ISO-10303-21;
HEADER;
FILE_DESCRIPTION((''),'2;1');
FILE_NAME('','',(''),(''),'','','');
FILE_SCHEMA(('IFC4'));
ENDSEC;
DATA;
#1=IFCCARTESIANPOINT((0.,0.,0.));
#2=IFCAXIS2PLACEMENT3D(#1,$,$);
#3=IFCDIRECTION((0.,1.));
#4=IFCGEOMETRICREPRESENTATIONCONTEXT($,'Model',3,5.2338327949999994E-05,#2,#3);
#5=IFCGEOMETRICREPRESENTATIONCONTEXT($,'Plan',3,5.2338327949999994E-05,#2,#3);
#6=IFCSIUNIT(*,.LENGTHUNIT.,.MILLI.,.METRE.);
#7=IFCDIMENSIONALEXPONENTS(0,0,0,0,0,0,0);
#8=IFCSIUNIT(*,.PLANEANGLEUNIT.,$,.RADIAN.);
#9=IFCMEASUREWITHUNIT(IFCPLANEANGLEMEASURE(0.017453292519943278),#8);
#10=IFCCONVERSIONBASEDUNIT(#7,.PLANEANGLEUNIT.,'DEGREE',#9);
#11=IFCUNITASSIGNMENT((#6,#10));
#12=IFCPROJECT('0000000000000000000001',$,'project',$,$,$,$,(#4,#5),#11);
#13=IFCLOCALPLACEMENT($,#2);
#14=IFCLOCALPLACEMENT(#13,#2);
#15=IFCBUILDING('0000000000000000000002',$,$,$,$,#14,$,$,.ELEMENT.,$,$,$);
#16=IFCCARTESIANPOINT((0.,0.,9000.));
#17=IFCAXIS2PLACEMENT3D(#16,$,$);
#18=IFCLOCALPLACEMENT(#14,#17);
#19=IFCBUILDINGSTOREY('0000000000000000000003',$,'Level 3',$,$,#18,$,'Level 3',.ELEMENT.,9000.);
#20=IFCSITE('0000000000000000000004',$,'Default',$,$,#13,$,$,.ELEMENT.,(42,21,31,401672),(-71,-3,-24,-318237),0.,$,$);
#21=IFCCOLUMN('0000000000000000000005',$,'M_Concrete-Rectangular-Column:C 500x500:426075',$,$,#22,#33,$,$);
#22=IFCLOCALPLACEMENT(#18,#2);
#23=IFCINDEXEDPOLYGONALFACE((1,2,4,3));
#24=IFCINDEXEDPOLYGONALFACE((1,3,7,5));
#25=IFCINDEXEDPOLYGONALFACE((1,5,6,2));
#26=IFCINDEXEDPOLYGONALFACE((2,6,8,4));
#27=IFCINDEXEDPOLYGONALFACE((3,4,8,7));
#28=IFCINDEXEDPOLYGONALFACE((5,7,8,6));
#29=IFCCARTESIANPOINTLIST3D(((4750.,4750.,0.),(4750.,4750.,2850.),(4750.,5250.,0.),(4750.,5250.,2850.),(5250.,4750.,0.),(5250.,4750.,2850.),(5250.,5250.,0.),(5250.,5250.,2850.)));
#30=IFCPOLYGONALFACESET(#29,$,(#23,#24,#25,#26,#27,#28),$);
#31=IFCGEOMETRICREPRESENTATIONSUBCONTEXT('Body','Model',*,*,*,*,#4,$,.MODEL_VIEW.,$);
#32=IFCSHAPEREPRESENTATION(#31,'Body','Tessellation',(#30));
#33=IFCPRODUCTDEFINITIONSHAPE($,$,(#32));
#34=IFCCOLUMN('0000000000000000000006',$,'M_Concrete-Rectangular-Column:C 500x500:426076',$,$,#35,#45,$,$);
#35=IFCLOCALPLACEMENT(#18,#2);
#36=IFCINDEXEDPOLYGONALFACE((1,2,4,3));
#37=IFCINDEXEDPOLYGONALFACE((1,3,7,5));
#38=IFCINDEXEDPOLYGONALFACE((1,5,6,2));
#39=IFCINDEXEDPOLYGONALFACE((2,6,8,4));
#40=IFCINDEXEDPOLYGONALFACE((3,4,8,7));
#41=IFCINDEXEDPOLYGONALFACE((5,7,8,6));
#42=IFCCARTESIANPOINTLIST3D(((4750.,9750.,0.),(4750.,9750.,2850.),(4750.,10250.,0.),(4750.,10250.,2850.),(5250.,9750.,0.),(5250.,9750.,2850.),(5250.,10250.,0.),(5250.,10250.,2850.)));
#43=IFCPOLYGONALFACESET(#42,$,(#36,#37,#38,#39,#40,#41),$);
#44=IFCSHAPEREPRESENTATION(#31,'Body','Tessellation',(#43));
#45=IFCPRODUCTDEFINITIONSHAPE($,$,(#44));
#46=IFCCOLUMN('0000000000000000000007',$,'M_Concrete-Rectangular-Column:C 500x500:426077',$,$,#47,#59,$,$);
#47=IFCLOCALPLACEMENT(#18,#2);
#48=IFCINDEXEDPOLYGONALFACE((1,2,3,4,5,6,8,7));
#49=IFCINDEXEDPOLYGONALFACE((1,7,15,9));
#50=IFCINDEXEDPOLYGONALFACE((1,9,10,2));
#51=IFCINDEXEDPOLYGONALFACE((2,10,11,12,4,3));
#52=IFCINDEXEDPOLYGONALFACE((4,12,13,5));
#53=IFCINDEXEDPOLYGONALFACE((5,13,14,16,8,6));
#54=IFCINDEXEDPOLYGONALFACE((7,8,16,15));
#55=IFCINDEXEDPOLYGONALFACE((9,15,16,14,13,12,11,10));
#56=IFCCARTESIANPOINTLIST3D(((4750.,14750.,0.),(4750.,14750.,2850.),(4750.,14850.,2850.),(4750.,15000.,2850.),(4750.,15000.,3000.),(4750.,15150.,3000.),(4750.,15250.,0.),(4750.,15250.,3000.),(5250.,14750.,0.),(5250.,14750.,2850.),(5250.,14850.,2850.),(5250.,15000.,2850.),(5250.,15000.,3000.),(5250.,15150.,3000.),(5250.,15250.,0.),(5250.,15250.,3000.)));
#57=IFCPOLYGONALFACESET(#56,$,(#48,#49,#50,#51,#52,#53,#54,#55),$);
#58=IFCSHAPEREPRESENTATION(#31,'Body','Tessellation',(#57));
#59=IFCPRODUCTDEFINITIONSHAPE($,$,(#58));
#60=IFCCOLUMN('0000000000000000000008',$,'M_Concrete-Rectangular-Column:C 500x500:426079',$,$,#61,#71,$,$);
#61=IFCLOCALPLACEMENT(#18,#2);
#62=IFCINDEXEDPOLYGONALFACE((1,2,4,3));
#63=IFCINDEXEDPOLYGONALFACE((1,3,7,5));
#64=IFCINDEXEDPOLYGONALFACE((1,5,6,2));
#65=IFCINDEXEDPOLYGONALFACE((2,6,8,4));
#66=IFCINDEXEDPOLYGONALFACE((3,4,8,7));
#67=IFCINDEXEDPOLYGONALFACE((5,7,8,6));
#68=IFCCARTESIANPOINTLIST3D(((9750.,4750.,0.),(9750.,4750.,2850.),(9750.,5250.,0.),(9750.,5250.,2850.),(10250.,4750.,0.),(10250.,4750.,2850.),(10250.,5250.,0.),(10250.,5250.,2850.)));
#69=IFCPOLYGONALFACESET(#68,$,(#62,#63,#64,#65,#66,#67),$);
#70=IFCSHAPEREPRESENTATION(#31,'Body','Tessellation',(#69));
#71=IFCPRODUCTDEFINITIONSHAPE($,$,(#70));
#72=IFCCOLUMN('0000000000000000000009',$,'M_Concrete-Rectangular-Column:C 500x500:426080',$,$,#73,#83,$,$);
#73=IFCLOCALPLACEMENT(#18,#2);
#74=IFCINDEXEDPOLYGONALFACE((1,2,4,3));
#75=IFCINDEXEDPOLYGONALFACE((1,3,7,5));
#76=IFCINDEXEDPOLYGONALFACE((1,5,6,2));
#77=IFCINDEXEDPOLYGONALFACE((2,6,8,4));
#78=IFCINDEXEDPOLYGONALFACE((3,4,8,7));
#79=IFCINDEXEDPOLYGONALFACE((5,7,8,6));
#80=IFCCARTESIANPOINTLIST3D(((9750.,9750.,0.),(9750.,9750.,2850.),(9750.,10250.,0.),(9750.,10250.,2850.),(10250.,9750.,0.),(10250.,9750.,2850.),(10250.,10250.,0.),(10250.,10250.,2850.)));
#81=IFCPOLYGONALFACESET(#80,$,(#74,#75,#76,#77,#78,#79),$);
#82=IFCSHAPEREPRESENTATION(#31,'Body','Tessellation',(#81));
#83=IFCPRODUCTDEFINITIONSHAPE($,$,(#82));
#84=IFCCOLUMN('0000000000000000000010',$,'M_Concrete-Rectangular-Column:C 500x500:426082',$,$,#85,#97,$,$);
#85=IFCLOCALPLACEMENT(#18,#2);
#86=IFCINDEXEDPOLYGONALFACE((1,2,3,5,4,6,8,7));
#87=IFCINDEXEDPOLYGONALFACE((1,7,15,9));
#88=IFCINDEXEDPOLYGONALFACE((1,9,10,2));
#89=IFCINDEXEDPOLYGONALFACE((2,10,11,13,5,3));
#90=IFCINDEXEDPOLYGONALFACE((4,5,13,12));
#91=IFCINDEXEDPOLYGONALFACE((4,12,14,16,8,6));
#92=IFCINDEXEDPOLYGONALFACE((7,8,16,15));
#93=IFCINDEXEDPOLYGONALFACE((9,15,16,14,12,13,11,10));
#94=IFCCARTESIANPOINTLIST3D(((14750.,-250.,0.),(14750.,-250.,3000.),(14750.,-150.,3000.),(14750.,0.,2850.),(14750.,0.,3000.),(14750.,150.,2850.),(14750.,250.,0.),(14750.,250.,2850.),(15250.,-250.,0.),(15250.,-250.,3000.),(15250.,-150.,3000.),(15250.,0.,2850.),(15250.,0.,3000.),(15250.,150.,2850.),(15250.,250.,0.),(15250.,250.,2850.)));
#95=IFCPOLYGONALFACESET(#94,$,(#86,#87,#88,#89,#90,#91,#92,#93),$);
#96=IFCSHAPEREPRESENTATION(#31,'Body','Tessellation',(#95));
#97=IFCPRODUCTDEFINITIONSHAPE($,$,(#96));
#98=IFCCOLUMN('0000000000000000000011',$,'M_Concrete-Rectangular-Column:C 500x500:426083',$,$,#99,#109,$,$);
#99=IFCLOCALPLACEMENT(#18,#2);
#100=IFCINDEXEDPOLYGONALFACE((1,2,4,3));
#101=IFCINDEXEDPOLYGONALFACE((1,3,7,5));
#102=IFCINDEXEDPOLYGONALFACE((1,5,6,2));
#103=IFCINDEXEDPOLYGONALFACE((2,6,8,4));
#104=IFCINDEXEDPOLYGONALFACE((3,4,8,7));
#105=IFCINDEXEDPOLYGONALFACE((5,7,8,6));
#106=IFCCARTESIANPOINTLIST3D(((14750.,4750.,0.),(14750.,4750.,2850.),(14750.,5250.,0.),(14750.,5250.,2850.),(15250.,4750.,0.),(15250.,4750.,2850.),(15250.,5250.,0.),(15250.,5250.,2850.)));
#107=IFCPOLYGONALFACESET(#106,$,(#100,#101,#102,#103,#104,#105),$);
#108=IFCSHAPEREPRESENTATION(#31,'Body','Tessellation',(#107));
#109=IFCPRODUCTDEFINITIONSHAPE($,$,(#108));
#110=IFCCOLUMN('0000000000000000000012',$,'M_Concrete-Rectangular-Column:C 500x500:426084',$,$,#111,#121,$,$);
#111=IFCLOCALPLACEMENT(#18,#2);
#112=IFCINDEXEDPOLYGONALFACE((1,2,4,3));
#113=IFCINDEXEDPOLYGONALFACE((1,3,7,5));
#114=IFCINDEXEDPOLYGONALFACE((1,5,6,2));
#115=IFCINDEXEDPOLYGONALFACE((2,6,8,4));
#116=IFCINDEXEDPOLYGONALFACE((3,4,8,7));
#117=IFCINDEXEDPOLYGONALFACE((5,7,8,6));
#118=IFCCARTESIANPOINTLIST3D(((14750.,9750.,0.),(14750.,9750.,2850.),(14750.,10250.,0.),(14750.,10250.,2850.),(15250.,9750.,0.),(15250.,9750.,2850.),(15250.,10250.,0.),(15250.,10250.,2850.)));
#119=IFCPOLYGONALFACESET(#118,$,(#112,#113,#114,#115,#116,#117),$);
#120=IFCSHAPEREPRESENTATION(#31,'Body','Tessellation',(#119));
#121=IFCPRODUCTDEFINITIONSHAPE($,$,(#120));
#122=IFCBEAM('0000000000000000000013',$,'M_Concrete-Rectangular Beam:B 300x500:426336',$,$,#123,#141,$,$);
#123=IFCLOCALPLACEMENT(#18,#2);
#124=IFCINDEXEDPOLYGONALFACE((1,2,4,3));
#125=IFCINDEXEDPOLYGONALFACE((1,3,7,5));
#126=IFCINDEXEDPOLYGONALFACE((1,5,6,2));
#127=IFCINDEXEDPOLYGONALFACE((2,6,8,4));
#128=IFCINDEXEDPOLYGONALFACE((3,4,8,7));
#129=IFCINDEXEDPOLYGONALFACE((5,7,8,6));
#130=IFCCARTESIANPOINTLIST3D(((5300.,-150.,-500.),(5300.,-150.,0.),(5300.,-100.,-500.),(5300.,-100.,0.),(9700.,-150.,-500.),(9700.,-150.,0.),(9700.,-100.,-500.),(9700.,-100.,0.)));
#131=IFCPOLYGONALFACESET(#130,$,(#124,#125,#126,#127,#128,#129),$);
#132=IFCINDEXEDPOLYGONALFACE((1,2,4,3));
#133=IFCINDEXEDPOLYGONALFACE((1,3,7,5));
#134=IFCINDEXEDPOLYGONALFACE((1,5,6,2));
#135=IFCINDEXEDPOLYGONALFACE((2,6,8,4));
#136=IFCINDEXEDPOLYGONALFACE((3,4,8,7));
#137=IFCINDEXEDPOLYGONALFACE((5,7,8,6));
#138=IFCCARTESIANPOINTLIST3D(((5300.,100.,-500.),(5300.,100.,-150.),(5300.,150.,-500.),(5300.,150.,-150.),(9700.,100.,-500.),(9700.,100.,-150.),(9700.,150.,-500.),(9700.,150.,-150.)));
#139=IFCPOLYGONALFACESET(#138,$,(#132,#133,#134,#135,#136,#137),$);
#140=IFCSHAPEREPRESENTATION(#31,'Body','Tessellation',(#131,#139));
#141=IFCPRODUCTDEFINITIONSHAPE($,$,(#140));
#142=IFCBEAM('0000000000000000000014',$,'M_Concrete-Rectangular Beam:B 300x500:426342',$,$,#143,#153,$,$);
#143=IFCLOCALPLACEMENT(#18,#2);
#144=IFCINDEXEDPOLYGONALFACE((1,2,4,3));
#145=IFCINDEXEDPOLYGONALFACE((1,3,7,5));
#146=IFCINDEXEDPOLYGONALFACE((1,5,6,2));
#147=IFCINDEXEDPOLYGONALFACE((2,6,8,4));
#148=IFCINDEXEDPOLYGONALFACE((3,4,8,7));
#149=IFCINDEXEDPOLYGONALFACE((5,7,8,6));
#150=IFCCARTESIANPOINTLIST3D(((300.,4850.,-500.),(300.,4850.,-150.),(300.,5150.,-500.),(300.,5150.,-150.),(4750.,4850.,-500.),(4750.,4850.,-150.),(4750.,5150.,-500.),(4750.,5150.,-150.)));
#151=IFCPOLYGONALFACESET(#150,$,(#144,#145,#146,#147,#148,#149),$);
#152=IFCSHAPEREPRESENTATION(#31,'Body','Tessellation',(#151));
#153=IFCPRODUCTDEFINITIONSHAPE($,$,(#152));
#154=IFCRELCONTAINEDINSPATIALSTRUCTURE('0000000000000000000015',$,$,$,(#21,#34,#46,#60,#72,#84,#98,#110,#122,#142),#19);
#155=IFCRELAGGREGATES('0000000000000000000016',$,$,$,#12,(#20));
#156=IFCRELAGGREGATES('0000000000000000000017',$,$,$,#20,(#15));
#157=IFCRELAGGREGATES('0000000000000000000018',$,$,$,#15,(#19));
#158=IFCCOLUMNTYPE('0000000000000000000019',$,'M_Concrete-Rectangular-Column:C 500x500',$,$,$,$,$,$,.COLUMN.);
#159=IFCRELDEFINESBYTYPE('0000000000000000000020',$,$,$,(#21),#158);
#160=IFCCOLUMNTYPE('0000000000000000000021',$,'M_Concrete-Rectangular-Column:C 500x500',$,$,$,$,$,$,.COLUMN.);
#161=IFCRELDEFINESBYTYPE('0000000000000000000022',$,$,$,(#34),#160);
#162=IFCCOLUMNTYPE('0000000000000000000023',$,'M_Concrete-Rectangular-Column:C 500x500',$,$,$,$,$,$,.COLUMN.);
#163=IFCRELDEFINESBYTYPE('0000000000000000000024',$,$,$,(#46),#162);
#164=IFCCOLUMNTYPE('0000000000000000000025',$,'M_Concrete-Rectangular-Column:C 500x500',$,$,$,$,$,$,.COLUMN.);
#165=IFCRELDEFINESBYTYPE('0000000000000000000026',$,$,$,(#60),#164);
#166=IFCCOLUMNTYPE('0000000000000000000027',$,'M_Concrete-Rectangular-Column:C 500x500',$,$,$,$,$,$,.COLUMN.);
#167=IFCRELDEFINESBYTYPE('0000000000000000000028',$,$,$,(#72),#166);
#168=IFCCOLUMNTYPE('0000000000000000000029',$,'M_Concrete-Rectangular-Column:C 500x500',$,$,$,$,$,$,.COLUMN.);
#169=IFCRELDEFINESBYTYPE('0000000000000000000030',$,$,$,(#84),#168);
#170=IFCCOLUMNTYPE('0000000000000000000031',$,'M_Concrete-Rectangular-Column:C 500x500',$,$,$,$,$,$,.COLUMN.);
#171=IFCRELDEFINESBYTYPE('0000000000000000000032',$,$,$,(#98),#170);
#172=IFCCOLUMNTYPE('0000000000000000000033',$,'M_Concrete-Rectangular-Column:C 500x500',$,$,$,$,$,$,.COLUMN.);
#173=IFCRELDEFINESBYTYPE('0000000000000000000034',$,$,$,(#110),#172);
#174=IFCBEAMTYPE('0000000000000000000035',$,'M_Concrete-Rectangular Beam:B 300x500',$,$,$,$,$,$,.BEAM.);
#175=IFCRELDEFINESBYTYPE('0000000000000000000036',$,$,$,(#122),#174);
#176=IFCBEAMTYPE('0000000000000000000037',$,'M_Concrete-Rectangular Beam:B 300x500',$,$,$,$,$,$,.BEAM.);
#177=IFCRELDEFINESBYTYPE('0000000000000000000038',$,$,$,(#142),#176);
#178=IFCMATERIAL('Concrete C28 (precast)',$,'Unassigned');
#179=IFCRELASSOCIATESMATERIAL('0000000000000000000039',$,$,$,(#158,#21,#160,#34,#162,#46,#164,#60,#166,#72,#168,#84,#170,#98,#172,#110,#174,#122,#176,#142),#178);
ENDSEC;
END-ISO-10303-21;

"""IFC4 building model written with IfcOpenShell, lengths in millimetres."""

from ifc_helpers import new_model, entity, si_unit, converted_unit, direction, frame, origin, place, context, subcontext, project, spatial, indexed_curve, outline, extrude, source, transform, mapped, material, type_object, type_shapes, element, save


model = new_model("IFC4")

# Units and contexts
model_context = context("Model", 3, precision=5.2338327949999994e-05, world=origin(), true_north=direction((0.0, 1.0)))
plan_context = context("Plan", 3, precision=5.2338327949999994e-05, world=origin(), true_north=direction((0.0, 1.0)))
body_context = subcontext(model_context, "Body", "Model", "MODEL_VIEW")
ifc_project = project(units=[si_unit("LENGTHUNIT", "METRE", prefix="MILLI"), converted_unit("PLANEANGLEUNIT", "DEGREE", entity("IfcPlaneAngleMeasure", 0.017453292519943278), si_unit("PLANEANGLEUNIT", "RADIAN"), dimensions=[0, 0, 0, 0, 0, 0, 0])], contexts=[model_context, plan_context])

# Site, building, storey
site_placement = place(None, origin())
site = spatial("IfcSite", under=ifc_project, at=site_placement, Name="Default", CompositionType="ELEMENT", RefLatitude=(42, 21, 31, 401672), RefLongitude=(-71, -3, -24, -318237), RefElevation=0.0)
building_placement = place(site_placement, origin())
building = spatial("IfcBuilding", under=site, at=building_placement, CompositionType="ELEMENT")
storey_placement = place(building_placement, frame((0.0, 0.0, 9000.0)))
storey = spatial("IfcBuildingStorey", under=building, at=storey_placement, Name="Level 3", LongName="Level 3", CompositionType="ELEMENT", Elevation=9000.0)

# Columns
ifc_material = material(Name="Concrete C28 (precast)", Category="Unassigned")
column_type_1 = type_object("IfcColumnType", Name="M_Concrete-Rectangular-Column:C 500x500", PredefinedType="COLUMN", material=ifc_material)
shared_shape_1 = source(origin(), body_context, "Body", "SweptSolid", [
    extrude(outline(indexed_curve([(-250.0, -250.0), (250.0, -250.0), (250.0, 250.0), (-250.0, 250.0), (-250.0, -250.0)], self_intersect=False)), frame((5000.0, 5000.0, 9000.0), z_axis=(0.0, 0.0, 1.0), x_axis=(-1.0, 0.0, 0.0)), (0.0, 0.0, 1.0), 2850.0),
])
type_shapes(column_type_1, [shared_shape_1])
column_1_placement = place(storey_placement, frame((0.0, 0.0, -9000.0)))
element("IfcColumn", 1, at=column_1_placement, inside=storey, type_object=column_type_1, material=ifc_material, Name="M_Concrete-Rectangular-Column:C 500x500:426075", context=body_context, shape_type="MappedRepresentation", body=[
    mapped(shared_shape_1, transform((0.0, 0.0, 0.0), scale=1.0)),
])
column_type_2 = type_object("IfcColumnType", Name="M_Concrete-Rectangular-Column:C 500x500", PredefinedType="COLUMN", material=ifc_material)
shared_shape_2 = source(origin(), body_context, "Body", "SweptSolid", [
    extrude(outline(indexed_curve([(-250.0, -250.0), (250.0, -250.0), (250.0, 250.0), (-250.0, 250.0), (-250.0, -250.0)], self_intersect=False)), frame((5000.0, 10000.0, 9000.0), z_axis=(0.0, 0.0, 1.0), x_axis=(-1.0, 0.0, 0.0)), (0.0, 0.0, 1.0), 2850.0),
])
type_shapes(column_type_2, [shared_shape_2])
column_2_placement = place(storey_placement, frame((0.0, 0.0, -9000.0)))
element("IfcColumn", 2, at=column_2_placement, inside=storey, type_object=column_type_2, material=ifc_material, Name="M_Concrete-Rectangular-Column:C 500x500:426076", context=body_context, shape_type="MappedRepresentation", body=[
    mapped(shared_shape_2, transform((0.0, 0.0, 0.0), scale=1.0)),
])
column_type_3 = type_object("IfcColumnType", Name="M_Concrete-Rectangular-Column:C 500x500", PredefinedType="COLUMN", material=ifc_material)
shared_shape_3 = source(origin(), body_context, "Body", "SweptSolid", [
    extrude(outline(indexed_curve([(-2193.8, -250.0), (806.2, -250.0), (806.2, -150.0), (806.2, 0.0), (656.2, 0.0), (656.2, 150.0), (656.2, 250.0), (-2193.8, 250.0), (-2193.8, -250.0)], self_intersect=False)), frame((4750.0, 15000.0, 11193.8), z_axis=(1.0, 0.0, 0.0), x_axis=(0.0, 0.0, 1.0)), (0.0, 0.0, 1.0), 500.0),
])
type_shapes(column_type_3, [shared_shape_3])
column_3_placement = place(storey_placement, frame((0.0, 0.0, -9000.0)))
element("IfcColumn", 3, at=column_3_placement, inside=storey, type_object=column_type_3, material=ifc_material, Name="M_Concrete-Rectangular-Column:C 500x500:426077", context=body_context, shape_type="MappedRepresentation", body=[
    mapped(shared_shape_3, transform((0.0, 0.0, 0.0), scale=1.0)),
])
column_type_4 = type_object("IfcColumnType", Name="M_Concrete-Rectangular-Column:C 500x500", PredefinedType="COLUMN", material=ifc_material)
shared_shape_4 = source(origin(), body_context, "Body", "SweptSolid", [
    extrude(outline(indexed_curve([(-250.0, -250.0), (250.0, -250.0), (250.0, 250.0), (-250.0, 250.0), (-250.0, -250.0)], self_intersect=False)), frame((10000.0, 5000.0, 9000.0), z_axis=(0.0, 0.0, 1.0), x_axis=(-1.0, 0.0, 0.0)), (0.0, 0.0, 1.0), 2850.0),
])
type_shapes(column_type_4, [shared_shape_4])
column_4_placement = place(storey_placement, frame((0.0, 0.0, -9000.0)))
element("IfcColumn", 4, at=column_4_placement, inside=storey, type_object=column_type_4, material=ifc_material, Name="M_Concrete-Rectangular-Column:C 500x500:426079", context=body_context, shape_type="MappedRepresentation", body=[
    mapped(shared_shape_4, transform((0.0, 0.0, 0.0), scale=1.0)),
])
column_type_5 = type_object("IfcColumnType", Name="M_Concrete-Rectangular-Column:C 500x500", PredefinedType="COLUMN", material=ifc_material)
shared_shape_5 = source(origin(), body_context, "Body", "SweptSolid", [
    extrude(outline(indexed_curve([(-250.0, -250.0), (250.0, -250.0), (250.0, 250.0), (-250.0, 250.0), (-250.0, -250.0)], self_intersect=False)), frame((10000.0, 10000.0, 9000.0), z_axis=(0.0, 0.0, 1.0), x_axis=(-1.0, 0.0, 0.0)), (0.0, 0.0, 1.0), 2850.0),
])
type_shapes(column_type_5, [shared_shape_5])
column_5_placement = place(storey_placement, frame((0.0, 0.0, -9000.0)))
element("IfcColumn", 5, at=column_5_placement, inside=storey, type_object=column_type_5, material=ifc_material, Name="M_Concrete-Rectangular-Column:C 500x500:426080", context=body_context, shape_type="MappedRepresentation", body=[
    mapped(shared_shape_5, transform((0.0, 0.0, 0.0), scale=1.0)),
])
column_type_6 = type_object("IfcColumnType", Name="M_Concrete-Rectangular-Column:C 500x500", PredefinedType="COLUMN", material=ifc_material)
shared_shape_6 = source(origin(), body_context, "Body", "SweptSolid", [
    extrude(outline(indexed_curve([(-2193.8, -250.0), (656.2, -250.0), (656.2, -150.0), (656.2, 0.0), (806.2, 0.0), (806.2, 150.0), (806.2, 250.0), (-2193.8, 250.0), (-2193.8, -250.0)], self_intersect=False)), frame((14750.0, 0.0, 11193.8), z_axis=(1.0, 0.0, 0.0), x_axis=(0.0, 0.0, 1.0)), (0.0, 0.0, 1.0), 500.0),
])
type_shapes(column_type_6, [shared_shape_6])
column_6_placement = place(storey_placement, frame((0.0, 0.0, -9000.0)))
element("IfcColumn", 6, at=column_6_placement, inside=storey, type_object=column_type_6, material=ifc_material, Name="M_Concrete-Rectangular-Column:C 500x500:426082", context=body_context, shape_type="MappedRepresentation", body=[
    mapped(shared_shape_6, transform((0.0, 0.0, 0.0), scale=1.0)),
])
column_type_7 = type_object("IfcColumnType", Name="M_Concrete-Rectangular-Column:C 500x500", PredefinedType="COLUMN", material=ifc_material)
shared_shape_7 = source(origin(), body_context, "Body", "SweptSolid", [
    extrude(outline(indexed_curve([(-250.0, -250.0), (250.0, -250.0), (250.0, 250.0), (-250.0, 250.0), (-250.0, -250.0)], self_intersect=False)), frame((15000.0, 5000.0, 9000.0), z_axis=(0.0, 0.0, 1.0), x_axis=(-1.0, 0.0, 0.0)), (0.0, 0.0, 1.0), 2850.0),
])
type_shapes(column_type_7, [shared_shape_7])
column_7_placement = place(storey_placement, frame((0.0, 0.0, -9000.0)))
element("IfcColumn", 7, at=column_7_placement, inside=storey, type_object=column_type_7, material=ifc_material, Name="M_Concrete-Rectangular-Column:C 500x500:426083", context=body_context, shape_type="MappedRepresentation", body=[
    mapped(shared_shape_7, transform((0.0, 0.0, 0.0), scale=1.0)),
])
column_type_8 = type_object("IfcColumnType", Name="M_Concrete-Rectangular-Column:C 500x500", PredefinedType="COLUMN", material=ifc_material)
shared_shape_8 = source(origin(), body_context, "Body", "SweptSolid", [
    extrude(outline(indexed_curve([(-250.0, -250.0), (250.0, -250.0), (250.0, 250.0), (-250.0, 250.0), (-250.0, -250.0)], self_intersect=False)), frame((15000.0, 10000.0, 9000.0), z_axis=(0.0, 0.0, 1.0), x_axis=(-1.0, 0.0, 0.0)), (0.0, 0.0, 1.0), 2850.0),
])
type_shapes(column_type_8, [shared_shape_8])
column_8_placement = place(storey_placement, frame((0.0, 0.0, -9000.0)))
element("IfcColumn", 8, at=column_8_placement, inside=storey, type_object=column_type_8, material=ifc_material, Name="M_Concrete-Rectangular-Column:C 500x500:426084", context=body_context, shape_type="MappedRepresentation", body=[
    mapped(shared_shape_8, transform((0.0, 0.0, 0.0), scale=1.0)),
])

# Beams
beam_type_1 = type_object("IfcBeamType", Name="M_Concrete-Rectangular Beam:B 300x500", PredefinedType="BEAM", material=ifc_material)
shared_shape_9 = source(origin(), body_context, "Body", "SweptSolid", [
    extrude(outline(indexed_curve([(-250.0, -25.0), (250.0, -25.0), (250.0, 25.0), (-250.0, 25.0), (-250.0, -25.0)], self_intersect=False)), frame((5300.0, -125.0, 8750.0), z_axis=(1.0, 0.0, 0.0), x_axis=(0.0, 0.0, -1.0)), (0.0, 0.0, 1.0), 4400.0),
    extrude(outline(indexed_curve([(-175.0, -25.0), (175.0, -25.0), (175.0, 25.0), (-175.0, 25.0), (-175.0, -25.0)], self_intersect=False)), frame((5300.0, 125.0, 8675.0), z_axis=(1.0, 0.0, 0.0), x_axis=(0.0, 0.0, -1.0)), (0.0, 0.0, 1.0), 4400.0),
])
type_shapes(beam_type_1, [shared_shape_9])
beam_1_placement = place(storey_placement, frame((0.0, 0.0, -9000.0)))
element("IfcBeam", 9, at=beam_1_placement, inside=storey, type_object=beam_type_1, material=ifc_material, Name="M_Concrete-Rectangular Beam:B 300x500:426336", context=body_context, shape_type="MappedRepresentation", body=[
    mapped(shared_shape_9, transform((0.0, 0.0, 0.0), scale=1.0)),
])
beam_type_2 = type_object("IfcBeamType", Name="M_Concrete-Rectangular Beam:B 300x500", PredefinedType="BEAM", material=ifc_material)
shared_shape_10 = source(origin(), body_context, "Body", "SweptSolid", [
    extrude(outline(indexed_curve([(-175.0, -150.0), (175.0, -150.0), (175.0, 150.0), (-175.0, 150.0), (-175.0, -150.0)], self_intersect=False)), frame((300.0, 5000.0, 8675.0), z_axis=(1.0, 0.0, 0.0), x_axis=(0.0, 0.0, -1.0)), (0.0, 0.0, 1.0), 4450.0),
])
type_shapes(beam_type_2, [shared_shape_10])
beam_2_placement = place(storey_placement, frame((0.0, 0.0, -9000.0)))
element("IfcBeam", 10, at=beam_2_placement, inside=storey, type_object=beam_type_2, material=ifc_material, Name="M_Concrete-Rectangular Beam:B 300x500:426342", context=body_context, shape_type="MappedRepresentation", body=[
    mapped(shared_shape_10, transform((0.0, 0.0, 0.0), scale=1.0)),
])

save(model, "model.ifc")
